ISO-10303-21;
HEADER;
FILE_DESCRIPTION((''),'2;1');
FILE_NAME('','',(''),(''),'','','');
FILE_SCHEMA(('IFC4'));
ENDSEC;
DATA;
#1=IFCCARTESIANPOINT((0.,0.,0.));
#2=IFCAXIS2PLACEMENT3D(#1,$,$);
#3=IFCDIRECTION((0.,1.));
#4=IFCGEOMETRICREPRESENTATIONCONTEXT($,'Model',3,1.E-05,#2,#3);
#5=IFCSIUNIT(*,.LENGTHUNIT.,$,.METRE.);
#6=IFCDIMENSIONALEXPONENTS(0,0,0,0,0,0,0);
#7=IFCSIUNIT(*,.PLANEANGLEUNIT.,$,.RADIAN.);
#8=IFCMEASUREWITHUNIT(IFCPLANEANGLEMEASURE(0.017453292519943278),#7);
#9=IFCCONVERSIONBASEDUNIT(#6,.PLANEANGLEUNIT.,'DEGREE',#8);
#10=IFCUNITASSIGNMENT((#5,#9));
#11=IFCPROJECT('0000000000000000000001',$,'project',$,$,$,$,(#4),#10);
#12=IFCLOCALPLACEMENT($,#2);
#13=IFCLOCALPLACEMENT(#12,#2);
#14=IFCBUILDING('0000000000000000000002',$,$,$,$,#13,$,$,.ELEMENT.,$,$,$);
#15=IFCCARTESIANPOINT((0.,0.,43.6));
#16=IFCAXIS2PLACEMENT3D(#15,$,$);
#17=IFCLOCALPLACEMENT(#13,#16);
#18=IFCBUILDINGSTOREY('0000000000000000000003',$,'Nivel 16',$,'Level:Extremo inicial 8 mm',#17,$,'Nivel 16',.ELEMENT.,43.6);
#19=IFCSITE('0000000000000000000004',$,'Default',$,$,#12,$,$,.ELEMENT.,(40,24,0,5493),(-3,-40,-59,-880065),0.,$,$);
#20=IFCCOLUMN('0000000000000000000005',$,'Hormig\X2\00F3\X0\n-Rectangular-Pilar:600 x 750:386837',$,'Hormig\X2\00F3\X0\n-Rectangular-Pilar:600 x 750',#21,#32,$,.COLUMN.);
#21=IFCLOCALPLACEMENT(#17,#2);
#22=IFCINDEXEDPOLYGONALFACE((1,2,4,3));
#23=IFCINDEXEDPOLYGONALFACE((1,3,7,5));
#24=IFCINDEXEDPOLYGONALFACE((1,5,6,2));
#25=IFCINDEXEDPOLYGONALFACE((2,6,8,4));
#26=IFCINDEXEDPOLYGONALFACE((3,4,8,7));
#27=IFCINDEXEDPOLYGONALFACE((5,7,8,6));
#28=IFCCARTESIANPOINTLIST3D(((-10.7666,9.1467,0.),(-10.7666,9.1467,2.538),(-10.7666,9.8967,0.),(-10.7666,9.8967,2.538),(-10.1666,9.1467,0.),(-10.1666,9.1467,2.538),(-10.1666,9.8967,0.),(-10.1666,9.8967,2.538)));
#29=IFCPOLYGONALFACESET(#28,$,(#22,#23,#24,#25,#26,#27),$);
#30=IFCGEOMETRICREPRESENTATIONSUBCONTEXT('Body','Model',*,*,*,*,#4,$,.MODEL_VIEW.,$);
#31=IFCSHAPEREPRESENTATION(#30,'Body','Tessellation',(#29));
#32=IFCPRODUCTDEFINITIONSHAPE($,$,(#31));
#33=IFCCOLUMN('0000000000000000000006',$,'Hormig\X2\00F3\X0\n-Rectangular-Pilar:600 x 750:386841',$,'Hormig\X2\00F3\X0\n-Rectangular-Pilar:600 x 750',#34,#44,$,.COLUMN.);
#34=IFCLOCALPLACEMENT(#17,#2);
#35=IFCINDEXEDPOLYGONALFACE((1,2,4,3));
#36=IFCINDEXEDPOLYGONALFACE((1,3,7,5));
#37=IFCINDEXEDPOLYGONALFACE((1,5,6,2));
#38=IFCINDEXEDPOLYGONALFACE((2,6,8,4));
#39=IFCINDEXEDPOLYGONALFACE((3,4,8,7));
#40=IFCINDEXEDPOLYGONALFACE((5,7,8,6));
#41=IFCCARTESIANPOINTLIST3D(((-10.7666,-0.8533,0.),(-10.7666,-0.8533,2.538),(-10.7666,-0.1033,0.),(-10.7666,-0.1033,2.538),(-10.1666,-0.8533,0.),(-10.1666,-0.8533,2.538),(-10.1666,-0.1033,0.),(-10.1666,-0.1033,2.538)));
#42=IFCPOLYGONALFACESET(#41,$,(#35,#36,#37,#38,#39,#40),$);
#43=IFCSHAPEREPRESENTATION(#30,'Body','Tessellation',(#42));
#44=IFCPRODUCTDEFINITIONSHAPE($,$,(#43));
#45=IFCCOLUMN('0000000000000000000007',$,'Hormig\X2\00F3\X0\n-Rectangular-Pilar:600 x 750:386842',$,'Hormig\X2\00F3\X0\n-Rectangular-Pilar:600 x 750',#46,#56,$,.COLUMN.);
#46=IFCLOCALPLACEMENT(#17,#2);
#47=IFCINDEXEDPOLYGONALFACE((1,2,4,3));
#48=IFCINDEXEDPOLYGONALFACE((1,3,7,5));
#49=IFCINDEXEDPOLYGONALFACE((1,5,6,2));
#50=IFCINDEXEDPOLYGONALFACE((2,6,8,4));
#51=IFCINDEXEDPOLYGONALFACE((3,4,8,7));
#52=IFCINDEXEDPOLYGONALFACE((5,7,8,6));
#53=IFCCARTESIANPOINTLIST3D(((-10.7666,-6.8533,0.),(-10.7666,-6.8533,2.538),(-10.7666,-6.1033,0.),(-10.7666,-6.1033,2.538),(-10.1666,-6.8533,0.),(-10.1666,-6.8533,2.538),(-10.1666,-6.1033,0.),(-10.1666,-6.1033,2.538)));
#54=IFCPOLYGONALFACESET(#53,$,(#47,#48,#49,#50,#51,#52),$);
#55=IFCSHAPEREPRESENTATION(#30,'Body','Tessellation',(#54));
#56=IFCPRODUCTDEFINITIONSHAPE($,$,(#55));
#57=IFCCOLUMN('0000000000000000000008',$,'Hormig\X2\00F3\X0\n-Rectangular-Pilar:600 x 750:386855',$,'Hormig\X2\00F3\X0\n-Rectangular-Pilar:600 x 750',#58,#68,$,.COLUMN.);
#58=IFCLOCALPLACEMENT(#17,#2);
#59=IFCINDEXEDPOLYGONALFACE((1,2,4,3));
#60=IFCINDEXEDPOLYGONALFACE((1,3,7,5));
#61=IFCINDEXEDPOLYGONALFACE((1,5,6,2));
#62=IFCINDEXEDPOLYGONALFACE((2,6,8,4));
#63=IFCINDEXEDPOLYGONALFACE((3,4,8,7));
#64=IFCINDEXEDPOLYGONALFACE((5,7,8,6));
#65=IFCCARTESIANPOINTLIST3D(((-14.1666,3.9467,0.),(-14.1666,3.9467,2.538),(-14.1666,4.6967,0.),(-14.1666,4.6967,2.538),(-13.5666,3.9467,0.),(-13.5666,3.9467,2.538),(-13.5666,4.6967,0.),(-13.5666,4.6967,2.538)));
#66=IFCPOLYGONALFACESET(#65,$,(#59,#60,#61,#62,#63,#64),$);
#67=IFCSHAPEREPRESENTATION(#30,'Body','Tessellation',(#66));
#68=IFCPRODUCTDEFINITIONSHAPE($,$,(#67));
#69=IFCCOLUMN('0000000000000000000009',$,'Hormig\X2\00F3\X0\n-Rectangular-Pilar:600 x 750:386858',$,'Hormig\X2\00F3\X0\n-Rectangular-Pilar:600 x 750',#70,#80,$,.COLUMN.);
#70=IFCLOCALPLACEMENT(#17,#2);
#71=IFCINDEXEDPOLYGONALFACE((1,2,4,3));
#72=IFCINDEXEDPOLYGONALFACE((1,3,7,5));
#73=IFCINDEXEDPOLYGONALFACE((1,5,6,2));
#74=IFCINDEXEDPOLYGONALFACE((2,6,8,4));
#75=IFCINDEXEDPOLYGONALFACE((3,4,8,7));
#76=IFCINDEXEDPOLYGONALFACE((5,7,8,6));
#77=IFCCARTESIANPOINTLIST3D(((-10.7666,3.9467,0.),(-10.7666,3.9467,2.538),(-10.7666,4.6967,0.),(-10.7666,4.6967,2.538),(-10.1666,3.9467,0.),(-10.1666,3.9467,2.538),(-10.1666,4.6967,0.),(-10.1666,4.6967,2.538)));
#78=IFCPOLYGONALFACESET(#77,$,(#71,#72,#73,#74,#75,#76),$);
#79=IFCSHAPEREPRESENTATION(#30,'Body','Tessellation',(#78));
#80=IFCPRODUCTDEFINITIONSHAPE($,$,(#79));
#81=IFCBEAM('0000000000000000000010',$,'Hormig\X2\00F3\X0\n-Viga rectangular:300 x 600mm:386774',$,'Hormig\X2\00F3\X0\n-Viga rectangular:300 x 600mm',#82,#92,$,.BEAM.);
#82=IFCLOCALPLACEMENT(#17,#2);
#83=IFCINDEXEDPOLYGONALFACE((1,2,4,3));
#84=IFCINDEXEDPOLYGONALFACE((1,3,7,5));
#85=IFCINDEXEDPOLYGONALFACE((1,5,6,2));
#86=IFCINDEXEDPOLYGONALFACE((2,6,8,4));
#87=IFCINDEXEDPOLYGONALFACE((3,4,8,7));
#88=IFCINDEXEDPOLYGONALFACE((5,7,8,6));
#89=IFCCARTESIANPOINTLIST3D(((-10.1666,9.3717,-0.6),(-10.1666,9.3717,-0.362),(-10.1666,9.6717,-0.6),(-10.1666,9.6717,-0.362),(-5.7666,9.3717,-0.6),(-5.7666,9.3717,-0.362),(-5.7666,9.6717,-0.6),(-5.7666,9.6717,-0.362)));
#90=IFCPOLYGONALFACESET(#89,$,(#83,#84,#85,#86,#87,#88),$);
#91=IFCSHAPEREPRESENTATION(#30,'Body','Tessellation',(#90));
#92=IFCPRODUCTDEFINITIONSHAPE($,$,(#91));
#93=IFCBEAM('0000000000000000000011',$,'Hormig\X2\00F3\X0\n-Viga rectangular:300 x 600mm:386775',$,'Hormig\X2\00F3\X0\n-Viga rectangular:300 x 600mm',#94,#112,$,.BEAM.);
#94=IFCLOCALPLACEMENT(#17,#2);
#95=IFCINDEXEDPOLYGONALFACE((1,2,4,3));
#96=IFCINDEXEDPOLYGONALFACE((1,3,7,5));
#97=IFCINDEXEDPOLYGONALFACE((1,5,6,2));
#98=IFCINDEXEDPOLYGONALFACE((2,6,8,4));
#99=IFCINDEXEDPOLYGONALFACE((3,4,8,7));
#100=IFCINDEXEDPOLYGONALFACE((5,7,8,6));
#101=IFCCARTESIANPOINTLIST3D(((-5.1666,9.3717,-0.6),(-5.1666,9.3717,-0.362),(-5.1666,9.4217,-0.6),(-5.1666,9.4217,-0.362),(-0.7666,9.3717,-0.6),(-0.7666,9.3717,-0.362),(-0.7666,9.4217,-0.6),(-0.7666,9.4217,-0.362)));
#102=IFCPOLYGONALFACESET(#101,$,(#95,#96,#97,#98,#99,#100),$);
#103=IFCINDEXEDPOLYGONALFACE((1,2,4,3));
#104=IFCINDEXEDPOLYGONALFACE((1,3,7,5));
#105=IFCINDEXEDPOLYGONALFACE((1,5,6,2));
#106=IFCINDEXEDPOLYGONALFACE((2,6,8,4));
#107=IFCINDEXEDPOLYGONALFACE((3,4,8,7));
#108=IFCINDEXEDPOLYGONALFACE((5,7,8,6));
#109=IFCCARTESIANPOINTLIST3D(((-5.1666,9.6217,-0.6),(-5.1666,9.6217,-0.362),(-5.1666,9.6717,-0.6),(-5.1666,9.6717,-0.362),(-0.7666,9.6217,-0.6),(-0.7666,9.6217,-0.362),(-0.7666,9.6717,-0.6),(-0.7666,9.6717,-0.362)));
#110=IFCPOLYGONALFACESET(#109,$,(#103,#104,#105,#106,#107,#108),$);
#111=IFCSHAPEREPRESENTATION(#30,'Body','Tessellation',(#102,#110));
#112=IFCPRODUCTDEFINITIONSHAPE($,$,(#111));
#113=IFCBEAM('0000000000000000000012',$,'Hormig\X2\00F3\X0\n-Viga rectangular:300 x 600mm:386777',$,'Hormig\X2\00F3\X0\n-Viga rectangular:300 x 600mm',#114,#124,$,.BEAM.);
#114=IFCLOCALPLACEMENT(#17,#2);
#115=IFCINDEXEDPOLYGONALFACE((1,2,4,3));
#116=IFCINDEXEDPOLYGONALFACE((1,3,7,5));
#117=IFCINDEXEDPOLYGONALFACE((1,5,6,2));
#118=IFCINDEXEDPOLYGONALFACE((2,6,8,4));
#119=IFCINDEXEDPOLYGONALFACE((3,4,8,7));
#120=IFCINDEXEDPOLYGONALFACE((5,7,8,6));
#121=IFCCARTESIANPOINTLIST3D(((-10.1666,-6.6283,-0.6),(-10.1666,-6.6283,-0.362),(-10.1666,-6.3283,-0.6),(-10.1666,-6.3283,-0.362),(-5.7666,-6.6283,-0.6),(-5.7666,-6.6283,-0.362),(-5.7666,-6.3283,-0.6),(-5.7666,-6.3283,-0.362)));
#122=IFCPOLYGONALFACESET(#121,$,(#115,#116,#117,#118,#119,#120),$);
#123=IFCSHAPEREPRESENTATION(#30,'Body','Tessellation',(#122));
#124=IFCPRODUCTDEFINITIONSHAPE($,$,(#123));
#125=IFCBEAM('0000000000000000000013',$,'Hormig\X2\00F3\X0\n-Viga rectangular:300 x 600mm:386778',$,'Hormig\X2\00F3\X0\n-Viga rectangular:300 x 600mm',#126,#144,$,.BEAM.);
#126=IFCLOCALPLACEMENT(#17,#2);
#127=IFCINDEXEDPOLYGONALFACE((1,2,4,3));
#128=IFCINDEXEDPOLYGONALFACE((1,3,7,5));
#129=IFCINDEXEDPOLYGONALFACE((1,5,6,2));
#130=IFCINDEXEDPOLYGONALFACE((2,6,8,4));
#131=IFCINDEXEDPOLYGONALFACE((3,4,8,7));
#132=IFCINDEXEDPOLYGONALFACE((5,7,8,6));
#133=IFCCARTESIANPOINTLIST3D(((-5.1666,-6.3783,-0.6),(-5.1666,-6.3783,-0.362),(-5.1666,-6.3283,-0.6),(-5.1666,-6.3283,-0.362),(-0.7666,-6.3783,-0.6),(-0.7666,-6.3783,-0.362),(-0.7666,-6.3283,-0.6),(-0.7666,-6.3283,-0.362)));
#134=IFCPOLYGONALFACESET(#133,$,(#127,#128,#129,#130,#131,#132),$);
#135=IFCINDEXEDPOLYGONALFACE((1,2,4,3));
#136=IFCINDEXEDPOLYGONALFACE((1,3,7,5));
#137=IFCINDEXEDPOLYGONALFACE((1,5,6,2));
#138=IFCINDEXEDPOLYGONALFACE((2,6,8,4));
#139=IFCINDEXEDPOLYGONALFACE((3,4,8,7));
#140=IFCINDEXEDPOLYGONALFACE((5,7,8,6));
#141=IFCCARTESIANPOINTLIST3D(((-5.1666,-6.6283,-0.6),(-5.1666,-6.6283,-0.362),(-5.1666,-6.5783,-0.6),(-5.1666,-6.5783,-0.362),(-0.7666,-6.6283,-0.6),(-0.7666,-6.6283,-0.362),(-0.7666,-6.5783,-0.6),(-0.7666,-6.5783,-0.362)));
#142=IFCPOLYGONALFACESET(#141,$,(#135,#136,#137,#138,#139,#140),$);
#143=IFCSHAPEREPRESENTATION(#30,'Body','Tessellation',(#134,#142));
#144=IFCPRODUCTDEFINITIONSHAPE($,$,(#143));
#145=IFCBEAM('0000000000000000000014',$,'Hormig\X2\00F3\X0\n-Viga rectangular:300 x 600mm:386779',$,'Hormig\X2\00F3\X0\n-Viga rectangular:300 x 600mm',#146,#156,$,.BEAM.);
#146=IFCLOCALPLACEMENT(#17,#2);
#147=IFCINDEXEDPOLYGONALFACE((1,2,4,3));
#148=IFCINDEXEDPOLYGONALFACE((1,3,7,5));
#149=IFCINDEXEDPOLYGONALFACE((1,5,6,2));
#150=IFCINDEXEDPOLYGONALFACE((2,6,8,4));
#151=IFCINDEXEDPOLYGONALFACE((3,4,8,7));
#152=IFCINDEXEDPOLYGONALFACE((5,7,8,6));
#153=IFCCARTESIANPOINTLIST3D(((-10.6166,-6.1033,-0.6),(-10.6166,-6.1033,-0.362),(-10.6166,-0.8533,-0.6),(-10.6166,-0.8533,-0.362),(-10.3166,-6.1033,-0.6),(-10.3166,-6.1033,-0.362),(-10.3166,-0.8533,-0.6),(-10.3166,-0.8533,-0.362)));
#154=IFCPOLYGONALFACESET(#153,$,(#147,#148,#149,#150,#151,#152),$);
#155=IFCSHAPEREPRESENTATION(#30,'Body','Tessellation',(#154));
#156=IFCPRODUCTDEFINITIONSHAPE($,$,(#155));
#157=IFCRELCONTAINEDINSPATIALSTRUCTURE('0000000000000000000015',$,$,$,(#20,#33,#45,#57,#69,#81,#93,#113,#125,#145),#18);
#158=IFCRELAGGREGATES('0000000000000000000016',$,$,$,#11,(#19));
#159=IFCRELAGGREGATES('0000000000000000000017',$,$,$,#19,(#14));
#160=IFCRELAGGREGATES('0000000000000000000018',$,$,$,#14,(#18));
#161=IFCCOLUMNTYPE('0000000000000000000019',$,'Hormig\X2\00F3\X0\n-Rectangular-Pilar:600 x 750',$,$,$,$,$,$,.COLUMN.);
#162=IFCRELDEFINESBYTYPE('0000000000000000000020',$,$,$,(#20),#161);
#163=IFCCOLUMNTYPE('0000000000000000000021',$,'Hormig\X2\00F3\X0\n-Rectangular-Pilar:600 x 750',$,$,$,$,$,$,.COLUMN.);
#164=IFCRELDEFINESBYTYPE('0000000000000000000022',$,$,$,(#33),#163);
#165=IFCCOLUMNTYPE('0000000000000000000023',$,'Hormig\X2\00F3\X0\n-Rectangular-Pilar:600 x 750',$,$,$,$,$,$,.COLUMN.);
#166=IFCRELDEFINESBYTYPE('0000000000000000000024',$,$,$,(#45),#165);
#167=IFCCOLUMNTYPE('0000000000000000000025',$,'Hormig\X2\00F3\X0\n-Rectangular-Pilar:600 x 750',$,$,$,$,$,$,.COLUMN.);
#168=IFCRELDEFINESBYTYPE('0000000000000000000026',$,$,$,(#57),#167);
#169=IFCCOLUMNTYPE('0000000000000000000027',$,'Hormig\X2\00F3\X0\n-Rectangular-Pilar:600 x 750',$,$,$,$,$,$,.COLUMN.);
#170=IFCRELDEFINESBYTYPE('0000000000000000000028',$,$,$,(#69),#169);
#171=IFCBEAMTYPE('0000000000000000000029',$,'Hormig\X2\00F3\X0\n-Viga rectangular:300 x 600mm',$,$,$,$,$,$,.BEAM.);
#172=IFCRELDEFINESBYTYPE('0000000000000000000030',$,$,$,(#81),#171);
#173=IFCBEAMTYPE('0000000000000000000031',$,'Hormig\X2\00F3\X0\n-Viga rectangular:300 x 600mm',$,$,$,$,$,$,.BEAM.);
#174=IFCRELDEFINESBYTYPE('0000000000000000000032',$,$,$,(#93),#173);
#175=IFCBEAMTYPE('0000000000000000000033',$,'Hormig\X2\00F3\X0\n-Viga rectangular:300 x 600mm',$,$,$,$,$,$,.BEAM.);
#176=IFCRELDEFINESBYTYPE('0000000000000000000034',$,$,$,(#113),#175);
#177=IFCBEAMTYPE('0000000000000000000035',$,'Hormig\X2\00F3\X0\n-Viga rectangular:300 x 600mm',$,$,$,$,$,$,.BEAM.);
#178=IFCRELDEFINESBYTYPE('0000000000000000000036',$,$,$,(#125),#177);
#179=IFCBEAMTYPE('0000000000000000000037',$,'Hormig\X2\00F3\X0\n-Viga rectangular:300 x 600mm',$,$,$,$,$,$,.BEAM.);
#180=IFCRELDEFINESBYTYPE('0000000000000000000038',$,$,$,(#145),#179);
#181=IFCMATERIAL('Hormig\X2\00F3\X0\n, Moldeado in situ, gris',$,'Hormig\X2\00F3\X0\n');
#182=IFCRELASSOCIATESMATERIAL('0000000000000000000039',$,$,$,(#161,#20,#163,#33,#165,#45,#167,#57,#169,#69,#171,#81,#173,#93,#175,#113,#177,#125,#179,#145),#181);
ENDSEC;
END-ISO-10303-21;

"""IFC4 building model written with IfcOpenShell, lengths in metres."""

from ifc_helpers import new_model, entity, si_unit, converted_unit, direction, frame, origin, place, context, subcontext, project, spatial, indexed_curve, outline, extrude, source, transform, mapped, material, type_object, type_shapes, element, save


model = new_model("IFC4")

# Units and contexts
model_context = context("Model", 3, precision=1e-05, world=origin(), true_north=direction((0.0, 1.0)))
body_context = subcontext(model_context, "Body", "Model", "MODEL_VIEW")
ifc_project = project(units=[si_unit("LENGTHUNIT", "METRE"), converted_unit("PLANEANGLEUNIT", "DEGREE", entity("IfcPlaneAngleMeasure", 0.017453292519943278), si_unit("PLANEANGLEUNIT", "RADIAN"), dimensions=[0, 0, 0, 0, 0, 0, 0])], contexts=[model_context])

# Site, building, storey
site_placement = place(None, origin())
site = spatial("IfcSite", under=ifc_project, at=site_placement, Name="Default", CompositionType="ELEMENT", RefLatitude=(40, 24, 0, 5493), RefLongitude=(-3, -40, -59, -880065), RefElevation=0.0)
building_placement = place(site_placement, origin())
building = spatial("IfcBuilding", under=site, at=building_placement, CompositionType="ELEMENT")
storey_placement = place(building_placement, frame((0.0, 0.0, 43.6)))
storey = spatial("IfcBuildingStorey", under=building, at=storey_placement, Name="Nivel 16", ObjectType="Level:Extremo inicial 8 mm", LongName="Nivel 16", CompositionType="ELEMENT", Elevation=43.6)

# Columns
ifc_material_1 = material(Name="Hormigón, Moldeado in situ, gris", Category="Hormigón")
column_type_1 = type_object("IfcColumnType", Name="Hormigón-Rectangular-Pilar:600 x 750", PredefinedType="COLUMN", material=ifc_material_1)
shared_shape_1 = source(origin(), body_context, "Body", "SweptSolid", [
    extrude(outline(indexed_curve([(-0.3, -0.375), (0.3, -0.375), (0.3, 0.375), (-0.3, 0.375), (-0.3, -0.375)], self_intersect=False)), frame((-10.4666, 9.5217, 43.6), z_axis=(0.0, 0.0, 1.0), x_axis=(-1.0, 0.0, 0.0)), (0.0, 0.0, 1.0), 2.538),
])
type_shapes(column_type_1, [shared_shape_1])
column_1_placement = place(storey_placement, frame((0.0, 0.0, -43.6)))
element("IfcColumn", 1, at=column_1_placement, inside=storey, type_object=column_type_1, material=ifc_material_1, Name="Hormigón-Rectangular-Pilar:600 x 750:386837", ObjectType="Hormigón-Rectangular-Pilar:600 x 750", PredefinedType="COLUMN", context=body_context, shape_type="MappedRepresentation", body=[
    mapped(shared_shape_1, transform((0.0, 0.0, 0.0), scale=1.0)),
])
column_type_2 = type_object("IfcColumnType", Name="Hormigón-Rectangular-Pilar:600 x 750", PredefinedType="COLUMN", material=ifc_material_1)
shared_shape_2 = source(origin(), body_context, "Body", "SweptSolid", [
    extrude(outline(indexed_curve([(-0.3, -0.375), (0.3, -0.375), (0.3, 0.375), (-0.3, 0.375), (-0.3, -0.375)], self_intersect=False)), frame((-10.4666, -0.4783, 43.6), z_axis=(0.0, 0.0, 1.0), x_axis=(-1.0, 0.0, 0.0)), (0.0, 0.0, 1.0), 2.538),
])
type_shapes(column_type_2, [shared_shape_2])
column_2_placement = place(storey_placement, frame((0.0, 0.0, -43.6)))
element("IfcColumn", 2, at=column_2_placement, inside=storey, type_object=column_type_2, material=ifc_material_1, Name="Hormigón-Rectangular-Pilar:600 x 750:386841", ObjectType="Hormigón-Rectangular-Pilar:600 x 750", PredefinedType="COLUMN", context=body_context, shape_type="MappedRepresentation", body=[
    mapped(shared_shape_2, transform((0.0, 0.0, 0.0), scale=1.0)),
])
column_type_3 = type_object("IfcColumnType", Name="Hormigón-Rectangular-Pilar:600 x 750", PredefinedType="COLUMN", material=ifc_material_1)
shared_shape_3 = source(origin(), body_context, "Body", "SweptSolid", [
    extrude(outline(indexed_curve([(-0.3, -0.375), (0.3, -0.375), (0.3, 0.375), (-0.3, 0.375), (-0.3, -0.375)], self_intersect=False)), frame((-10.4666, -6.4783, 43.6), z_axis=(0.0, 0.0, 1.0), x_axis=(-1.0, 0.0, 0.0)), (0.0, 0.0, 1.0), 2.538),
])
type_shapes(column_type_3, [shared_shape_3])
column_3_placement = place(storey_placement, frame((0.0, 0.0, -43.6)))
element("IfcColumn", 3, at=column_3_placement, inside=storey, type_object=column_type_3, material=ifc_material_1, Name="Hormigón-Rectangular-Pilar:600 x 750:386842", ObjectType="Hormigón-Rectangular-Pilar:600 x 750", PredefinedType="COLUMN", context=body_context, shape_type="MappedRepresentation", body=[
    mapped(shared_shape_3, transform((0.0, 0.0, 0.0), scale=1.0)),
])
column_type_4 = type_object("IfcColumnType", Name="Hormigón-Rectangular-Pilar:600 x 750", PredefinedType="COLUMN", material=ifc_material_1)
shared_shape_4 = source(origin(), body_context, "Body", "SweptSolid", [
    extrude(outline(indexed_curve([(-0.3, -0.375), (0.3, -0.375), (0.3, 0.375), (-0.3, 0.375), (-0.3, -0.375)], self_intersect=False)), frame((-13.8666, 4.3217, 43.6), z_axis=(0.0, 0.0, 1.0), x_axis=(-1.0, 0.0, 0.0)), (0.0, 0.0, 1.0), 2.538),
])
type_shapes(column_type_4, [shared_shape_4])
column_4_placement = place(storey_placement, frame((0.0, 0.0, -43.6)))
element("IfcColumn", 4, at=column_4_placement, inside=storey, type_object=column_type_4, material=ifc_material_1, Name="Hormigón-Rectangular-Pilar:600 x 750:386855", ObjectType="Hormigón-Rectangular-Pilar:600 x 750", PredefinedType="COLUMN", context=body_context, shape_type="MappedRepresentation", body=[
    mapped(shared_shape_4, transform((0.0, 0.0, 0.0), scale=1.0)),
])
column_type_5 = type_object("IfcColumnType", Name="Hormigón-Rectangular-Pilar:600 x 750", PredefinedType="COLUMN", material=ifc_material_1)
shared_shape_5 = source(origin(), body_context, "Body", "SweptSolid", [
    extrude(outline(indexed_curve([(-0.3, -0.375), (0.3, -0.375), (0.3, 0.375), (-0.3, 0.375), (-0.3, -0.375)], self_intersect=False)), frame((-10.4666, 4.3217, 43.6), z_axis=(0.0, 0.0, 1.0), x_axis=(-1.0, 0.0, 0.0)), (0.0, 0.0, 1.0), 2.538),
])
type_shapes(column_type_5, [shared_shape_5])
column_5_placement = place(storey_placement, frame((0.0, 0.0, -43.6)))
element("IfcColumn", 5, at=column_5_placement, inside=storey, type_object=column_type_5, material=ifc_material_1, Name="Hormigón-Rectangular-Pilar:600 x 750:386858", ObjectType="Hormigón-Rectangular-Pilar:600 x 750", PredefinedType="COLUMN", context=body_context, shape_type="MappedRepresentation", body=[
    mapped(shared_shape_5, transform((0.0, 0.0, 0.0), scale=1.0)),
])

# Beams
beam_type_1 = type_object("IfcBeamType", Name="Hormigón-Viga rectangular:300 x 600mm", PredefinedType="BEAM", material=ifc_material_1)
shared_shape_6 = source(origin(), body_context, "Body", "SweptSolid", [
    extrude(outline(indexed_curve([(-0.119, -0.15), (0.119, -0.15), (0.119, 0.15), (-0.119, 0.15), (-0.119, -0.15)], self_intersect=False)), frame((-5.7666, 9.5217, 43.119), z_axis=(-1.0, 0.0, 0.0), x_axis=(0.0, 0.0, -1.0)), (0.0, 0.0, 1.0), 4.4),
])
type_shapes(beam_type_1, [shared_shape_6])
beam_1_placement = place(storey_placement, frame((0.0, 0.0, -43.6)))
element("IfcBeam", 6, at=beam_1_placement, inside=storey, type_object=beam_type_1, material=ifc_material_1, Name="Hormigón-Viga rectangular:300 x 600mm:386774", ObjectType="Hormigón-Viga rectangular:300 x 600mm", PredefinedType="BEAM", context=body_context, shape_type="MappedRepresentation", body=[
    mapped(shared_shape_6, transform((0.0, 0.0, 0.0), scale=1.0)),
])
beam_type_2 = type_object("IfcBeamType", Name="Hormigón-Viga rectangular:300 x 600mm", PredefinedType="BEAM", material=ifc_material_1)
shared_shape_7 = source(origin(), body_context, "Body", "SweptSolid", [
    extrude(outline(indexed_curve([(-0.119, -0.025), (0.119, -0.025), (0.119, 0.025), (-0.119, 0.025), (-0.119, -0.025)], self_intersect=False)), frame((-5.1666, 9.3967, 43.119), z_axis=(1.0, 0.0, 0.0), x_axis=(0.0, 0.0, -1.0)), (0.0, 0.0, 1.0), 4.4),
    extrude(outline(indexed_curve([(-0.119, -0.025), (0.119, -0.025), (0.119, 0.025), (-0.119, 0.025), (-0.119, -0.025)], self_intersect=False)), frame((-5.1666, 9.6467, 43.119), z_axis=(1.0, 0.0, 0.0), x_axis=(0.0, 0.0, -1.0)), (0.0, 0.0, 1.0), 4.4),
])
type_shapes(beam_type_2, [shared_shape_7])
beam_2_placement = place(storey_placement, frame((0.0, 0.0, -43.6)))
element("IfcBeam", 7, at=beam_2_placement, inside=storey, type_object=beam_type_2, material=ifc_material_1, Name="Hormigón-Viga rectangular:300 x 600mm:386775", ObjectType="Hormigón-Viga rectangular:300 x 600mm", PredefinedType="BEAM", context=body_context, shape_type="MappedRepresentation", body=[
    mapped(shared_shape_7, transform((0.0, 0.0, 0.0), scale=1.0)),
])
beam_type_3 = type_object("IfcBeamType", Name="Hormigón-Viga rectangular:300 x 600mm", PredefinedType="BEAM", material=ifc_material_1)
shared_shape_8 = source(origin(), body_context, "Body", "SweptSolid", [
    extrude(outline(indexed_curve([(-0.119, -0.15), (0.119, -0.15), (0.119, 0.15), (-0.119, 0.15), (-0.119, -0.15)], self_intersect=False)), frame((-10.1666, -6.4783, 43.119), z_axis=(1.0, 0.0, 0.0), x_axis=(0.0, 0.0, -1.0)), (0.0, 0.0, 1.0), 4.4),
])
type_shapes(beam_type_3, [shared_shape_8])
beam_3_placement = place(storey_placement, frame((0.0, 0.0, -43.6)))
element("IfcBeam", 8, at=beam_3_placement, inside=storey, type_object=beam_type_3, material=ifc_material_1, Name="Hormigón-Viga rectangular:300 x 600mm:386777", ObjectType="Hormigón-Viga rectangular:300 x 600mm", PredefinedType="BEAM", context=body_context, shape_type="MappedRepresentation", body=[
    mapped(shared_shape_8, transform((0.0, 0.0, 0.0), scale=1.0)),
])
beam_type_4 = type_object("IfcBeamType", Name="Hormigón-Viga rectangular:300 x 600mm", PredefinedType="BEAM", material=ifc_material_1)
shared_shape_9 = source(origin(), body_context, "Body", "SweptSolid", [
    extrude(outline(indexed_curve([(-0.119, -0.025), (0.119, -0.025), (0.119, 0.025), (-0.119, 0.025), (-0.119, -0.025)], self_intersect=False)), frame((-0.7666, -6.3533, 43.119), z_axis=(-1.0, 0.0, 0.0), x_axis=(0.0, 0.0, -1.0)), (0.0, 0.0, 1.0), 4.4),
    extrude(outline(indexed_curve([(-0.119, -0.025), (0.119, -0.025), (0.119, 0.025), (-0.119, 0.025), (-0.119, -0.025)], self_intersect=False)), frame((-0.7666, -6.6033, 43.119), z_axis=(-1.0, 0.0, 0.0), x_axis=(0.0, 0.0, -1.0)), (0.0, 0.0, 1.0), 4.4),
])
type_shapes(beam_type_4, [shared_shape_9])
beam_4_placement = place(storey_placement, frame((0.0, 0.0, -43.6)))
element("IfcBeam", 9, at=beam_4_placement, inside=storey, type_object=beam_type_4, material=ifc_material_1, Name="Hormigón-Viga rectangular:300 x 600mm:386778", ObjectType="Hormigón-Viga rectangular:300 x 600mm", PredefinedType="BEAM", context=body_context, shape_type="MappedRepresentation", body=[
    mapped(shared_shape_9, transform((0.0, 0.0, 0.0), scale=1.0)),
])
beam_type_5 = type_object("IfcBeamType", Name="Hormigón-Viga rectangular:300 x 600mm", PredefinedType="BEAM", material=ifc_material_1)
shared_shape_10 = source(origin(), body_context, "Body", "SweptSolid", [
    extrude(outline(indexed_curve([(-0.15, -0.119), (0.15, -0.119), (0.15, 0.119), (-0.15, 0.119), (-0.15, -0.119)], self_intersect=False)), frame((-10.4666, -6.1033, 43.119), z_axis=(0.0, 1.0, 0.0), x_axis=(-1.0, 0.0, 0.0)), (0.0, 0.0, 1.0), 5.25),
])
type_shapes(beam_type_5, [shared_shape_10])
beam_5_placement = place(storey_placement, frame((0.0, 0.0, -43.6)))
element("IfcBeam", 10, at=beam_5_placement, inside=storey, type_object=beam_type_5, material=ifc_material_1, Name="Hormigón-Viga rectangular:300 x 600mm:386779", ObjectType="Hormigón-Viga rectangular:300 x 600mm", PredefinedType="BEAM", context=body_context, shape_type="MappedRepresentation", body=[
    mapped(shared_shape_10, transform((0.0, 0.0, 0.0), scale=1.0)),
])

save(model, "model.ifc")
